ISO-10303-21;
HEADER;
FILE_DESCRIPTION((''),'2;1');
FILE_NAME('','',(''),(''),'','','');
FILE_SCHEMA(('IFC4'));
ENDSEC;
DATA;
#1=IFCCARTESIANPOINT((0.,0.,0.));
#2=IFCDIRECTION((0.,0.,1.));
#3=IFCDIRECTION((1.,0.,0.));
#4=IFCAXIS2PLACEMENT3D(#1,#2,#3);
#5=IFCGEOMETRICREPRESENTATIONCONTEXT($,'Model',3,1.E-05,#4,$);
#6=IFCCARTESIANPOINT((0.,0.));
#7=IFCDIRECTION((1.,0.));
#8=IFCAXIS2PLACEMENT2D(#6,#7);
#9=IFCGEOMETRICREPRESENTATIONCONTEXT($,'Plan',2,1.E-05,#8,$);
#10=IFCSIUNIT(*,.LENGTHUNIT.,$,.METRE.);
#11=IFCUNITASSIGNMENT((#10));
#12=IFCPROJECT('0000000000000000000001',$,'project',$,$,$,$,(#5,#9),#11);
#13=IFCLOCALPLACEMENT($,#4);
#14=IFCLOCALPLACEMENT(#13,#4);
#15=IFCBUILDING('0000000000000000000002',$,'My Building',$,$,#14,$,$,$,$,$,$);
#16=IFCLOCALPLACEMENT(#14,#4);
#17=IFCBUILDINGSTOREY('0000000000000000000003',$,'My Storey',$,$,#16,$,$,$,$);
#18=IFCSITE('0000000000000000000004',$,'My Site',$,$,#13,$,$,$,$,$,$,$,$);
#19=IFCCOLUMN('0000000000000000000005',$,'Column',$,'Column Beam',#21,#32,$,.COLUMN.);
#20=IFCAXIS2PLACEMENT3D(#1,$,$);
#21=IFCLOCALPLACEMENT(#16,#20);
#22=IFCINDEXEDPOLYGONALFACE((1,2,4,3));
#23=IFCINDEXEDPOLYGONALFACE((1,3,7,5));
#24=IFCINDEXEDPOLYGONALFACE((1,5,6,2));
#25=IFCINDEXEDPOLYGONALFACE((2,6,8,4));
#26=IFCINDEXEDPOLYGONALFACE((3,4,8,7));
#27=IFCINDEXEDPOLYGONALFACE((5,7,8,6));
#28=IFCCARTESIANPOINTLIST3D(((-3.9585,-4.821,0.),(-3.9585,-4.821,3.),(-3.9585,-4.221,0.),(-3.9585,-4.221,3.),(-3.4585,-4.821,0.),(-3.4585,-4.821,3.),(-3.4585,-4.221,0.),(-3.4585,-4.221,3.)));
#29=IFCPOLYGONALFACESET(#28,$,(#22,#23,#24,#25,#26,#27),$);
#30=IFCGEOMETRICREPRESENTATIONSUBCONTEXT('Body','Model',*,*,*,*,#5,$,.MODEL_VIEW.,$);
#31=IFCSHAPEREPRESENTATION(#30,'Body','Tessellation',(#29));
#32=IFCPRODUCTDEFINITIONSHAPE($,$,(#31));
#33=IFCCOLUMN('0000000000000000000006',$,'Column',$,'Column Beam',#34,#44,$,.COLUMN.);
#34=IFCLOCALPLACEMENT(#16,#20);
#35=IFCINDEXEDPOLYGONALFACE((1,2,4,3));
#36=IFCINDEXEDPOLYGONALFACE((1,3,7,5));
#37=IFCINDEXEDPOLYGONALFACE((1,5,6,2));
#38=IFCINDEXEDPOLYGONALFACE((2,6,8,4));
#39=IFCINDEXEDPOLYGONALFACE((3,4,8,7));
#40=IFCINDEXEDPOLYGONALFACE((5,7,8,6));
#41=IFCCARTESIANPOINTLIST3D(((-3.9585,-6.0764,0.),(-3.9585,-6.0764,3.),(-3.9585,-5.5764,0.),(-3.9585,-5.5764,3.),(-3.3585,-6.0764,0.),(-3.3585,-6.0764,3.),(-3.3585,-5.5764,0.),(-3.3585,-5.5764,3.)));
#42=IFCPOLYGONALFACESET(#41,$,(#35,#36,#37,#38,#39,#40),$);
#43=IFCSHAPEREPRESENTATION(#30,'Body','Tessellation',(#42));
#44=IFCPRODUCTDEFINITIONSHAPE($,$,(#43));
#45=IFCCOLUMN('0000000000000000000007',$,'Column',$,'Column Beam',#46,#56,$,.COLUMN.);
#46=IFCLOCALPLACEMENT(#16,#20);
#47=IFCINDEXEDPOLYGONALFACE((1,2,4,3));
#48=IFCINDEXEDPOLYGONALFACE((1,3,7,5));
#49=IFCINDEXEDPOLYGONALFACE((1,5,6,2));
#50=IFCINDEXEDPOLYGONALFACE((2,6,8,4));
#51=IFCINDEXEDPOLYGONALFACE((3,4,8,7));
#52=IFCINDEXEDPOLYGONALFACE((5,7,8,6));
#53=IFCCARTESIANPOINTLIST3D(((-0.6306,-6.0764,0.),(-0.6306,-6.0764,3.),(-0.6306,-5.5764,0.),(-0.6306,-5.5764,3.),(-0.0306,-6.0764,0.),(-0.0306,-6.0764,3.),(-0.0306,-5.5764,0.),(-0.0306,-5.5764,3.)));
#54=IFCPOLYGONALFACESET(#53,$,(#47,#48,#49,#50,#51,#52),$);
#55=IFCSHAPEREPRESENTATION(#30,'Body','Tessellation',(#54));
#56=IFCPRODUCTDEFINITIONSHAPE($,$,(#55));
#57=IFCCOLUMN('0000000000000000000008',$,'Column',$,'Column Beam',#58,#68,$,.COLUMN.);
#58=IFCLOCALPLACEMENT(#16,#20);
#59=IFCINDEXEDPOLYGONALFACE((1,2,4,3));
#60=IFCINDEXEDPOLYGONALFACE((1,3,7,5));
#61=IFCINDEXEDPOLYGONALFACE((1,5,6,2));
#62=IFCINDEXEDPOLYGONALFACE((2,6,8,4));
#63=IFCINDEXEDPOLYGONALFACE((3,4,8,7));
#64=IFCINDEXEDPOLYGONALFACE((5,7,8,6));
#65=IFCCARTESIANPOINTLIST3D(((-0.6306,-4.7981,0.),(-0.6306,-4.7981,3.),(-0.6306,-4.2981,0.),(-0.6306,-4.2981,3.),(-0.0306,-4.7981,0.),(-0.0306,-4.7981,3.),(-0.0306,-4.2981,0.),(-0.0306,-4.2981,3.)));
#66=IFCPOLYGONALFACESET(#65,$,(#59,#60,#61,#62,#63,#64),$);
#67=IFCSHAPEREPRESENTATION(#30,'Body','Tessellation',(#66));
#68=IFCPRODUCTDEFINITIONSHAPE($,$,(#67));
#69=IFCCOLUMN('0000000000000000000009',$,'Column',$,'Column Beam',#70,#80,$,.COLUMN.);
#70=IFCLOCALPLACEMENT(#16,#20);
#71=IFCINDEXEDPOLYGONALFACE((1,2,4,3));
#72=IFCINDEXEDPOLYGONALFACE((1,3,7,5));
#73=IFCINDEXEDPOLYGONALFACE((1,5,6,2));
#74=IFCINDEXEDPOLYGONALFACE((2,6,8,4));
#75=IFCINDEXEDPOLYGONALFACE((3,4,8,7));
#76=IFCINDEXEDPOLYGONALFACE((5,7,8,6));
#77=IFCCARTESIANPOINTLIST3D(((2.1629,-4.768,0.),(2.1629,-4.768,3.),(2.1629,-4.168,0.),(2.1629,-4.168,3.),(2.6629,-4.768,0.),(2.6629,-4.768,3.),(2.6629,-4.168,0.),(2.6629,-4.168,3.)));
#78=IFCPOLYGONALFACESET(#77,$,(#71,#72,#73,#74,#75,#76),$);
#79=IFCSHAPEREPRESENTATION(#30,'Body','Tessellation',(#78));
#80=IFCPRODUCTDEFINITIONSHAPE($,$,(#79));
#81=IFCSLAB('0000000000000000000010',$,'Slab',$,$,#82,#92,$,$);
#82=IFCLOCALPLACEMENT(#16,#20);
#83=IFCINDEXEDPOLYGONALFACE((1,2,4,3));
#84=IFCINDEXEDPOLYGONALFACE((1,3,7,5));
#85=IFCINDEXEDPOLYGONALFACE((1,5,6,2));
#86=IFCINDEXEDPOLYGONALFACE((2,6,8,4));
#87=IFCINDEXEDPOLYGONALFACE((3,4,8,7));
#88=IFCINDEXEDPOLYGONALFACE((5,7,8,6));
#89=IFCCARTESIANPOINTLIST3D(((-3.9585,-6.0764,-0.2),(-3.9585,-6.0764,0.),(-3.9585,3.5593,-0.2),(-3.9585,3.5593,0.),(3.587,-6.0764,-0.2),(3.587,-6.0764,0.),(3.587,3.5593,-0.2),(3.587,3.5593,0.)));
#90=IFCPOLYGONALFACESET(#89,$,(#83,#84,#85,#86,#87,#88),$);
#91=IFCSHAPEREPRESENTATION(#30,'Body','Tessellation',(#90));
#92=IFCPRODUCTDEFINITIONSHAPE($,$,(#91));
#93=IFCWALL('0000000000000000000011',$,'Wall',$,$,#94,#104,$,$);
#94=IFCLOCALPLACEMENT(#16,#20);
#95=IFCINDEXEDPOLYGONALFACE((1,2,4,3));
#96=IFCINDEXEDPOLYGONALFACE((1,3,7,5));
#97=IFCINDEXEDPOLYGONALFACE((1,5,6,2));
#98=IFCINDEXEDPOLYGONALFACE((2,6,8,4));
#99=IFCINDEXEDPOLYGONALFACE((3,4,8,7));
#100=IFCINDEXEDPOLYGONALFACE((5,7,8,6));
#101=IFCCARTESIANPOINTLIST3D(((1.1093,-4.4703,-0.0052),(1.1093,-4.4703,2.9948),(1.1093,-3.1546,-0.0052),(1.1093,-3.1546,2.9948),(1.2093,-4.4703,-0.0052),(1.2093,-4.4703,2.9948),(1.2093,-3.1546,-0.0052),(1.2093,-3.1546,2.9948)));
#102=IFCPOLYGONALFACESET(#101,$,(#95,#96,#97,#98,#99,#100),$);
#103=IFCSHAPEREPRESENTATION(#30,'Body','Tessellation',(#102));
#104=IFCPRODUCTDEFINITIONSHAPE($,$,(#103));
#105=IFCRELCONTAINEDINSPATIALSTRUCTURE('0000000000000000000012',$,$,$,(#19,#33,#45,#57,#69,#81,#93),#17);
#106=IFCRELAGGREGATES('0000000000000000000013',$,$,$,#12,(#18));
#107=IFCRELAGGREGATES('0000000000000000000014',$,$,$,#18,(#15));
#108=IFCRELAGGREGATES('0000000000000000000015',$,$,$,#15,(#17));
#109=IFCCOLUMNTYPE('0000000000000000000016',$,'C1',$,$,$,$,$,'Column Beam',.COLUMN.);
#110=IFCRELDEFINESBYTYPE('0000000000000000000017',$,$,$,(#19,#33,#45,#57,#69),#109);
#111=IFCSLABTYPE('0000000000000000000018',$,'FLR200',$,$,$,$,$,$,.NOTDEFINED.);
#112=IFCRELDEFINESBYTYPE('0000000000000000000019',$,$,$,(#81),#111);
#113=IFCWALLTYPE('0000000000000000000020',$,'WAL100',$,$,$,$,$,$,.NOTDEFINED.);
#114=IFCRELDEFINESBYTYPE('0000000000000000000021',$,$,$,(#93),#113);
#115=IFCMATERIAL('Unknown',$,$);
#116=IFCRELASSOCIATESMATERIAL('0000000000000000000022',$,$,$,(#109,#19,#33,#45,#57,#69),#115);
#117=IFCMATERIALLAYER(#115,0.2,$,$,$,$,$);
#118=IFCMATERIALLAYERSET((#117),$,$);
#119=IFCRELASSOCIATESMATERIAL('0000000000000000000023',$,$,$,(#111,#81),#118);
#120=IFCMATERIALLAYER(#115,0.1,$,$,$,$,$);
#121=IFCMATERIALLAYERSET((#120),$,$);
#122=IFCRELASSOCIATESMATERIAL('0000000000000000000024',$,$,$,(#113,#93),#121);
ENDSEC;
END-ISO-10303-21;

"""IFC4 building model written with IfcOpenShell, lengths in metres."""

from ifc_helpers import new_model, si_unit, frame, origin_with_axes, origin_2d_with_axis, place, context, subcontext, project, spatial, line, indexed_curve, outline, extrude, material, layer, layer_set, layer_usage, material_profile, profile_set, profile_usage, type_object, element, save


model = new_model("IFC4")

# Units and contexts
model_context = context("Model", 3, precision=1e-05, world=origin_with_axes())
plan_context = context("Plan", 2, precision=1e-05, world=origin_2d_with_axis())
body_context_1 = subcontext(model_context, "Body", "Model", "MODEL_VIEW")
ifc_project = project(units=[si_unit("LENGTHUNIT", "METRE")], contexts=[model_context, plan_context])

# Site, building, storey
site_placement = place(None, origin_with_axes())
site = spatial("IfcSite", under=ifc_project, at=site_placement, Name="My Site")
building_placement = place(site_placement, origin_with_axes())
building = spatial("IfcBuilding", under=site, at=building_placement, Name="My Building")
storey_placement = place(building_placement, origin_with_axes())
storey = spatial("IfcBuildingStorey", under=building, at=storey_placement, Name="My Storey")

# Columns
ifc_material = material(Name="Unknown")
ifc_material_profile = material_profile(ifc_material, outline(indexed_curve([(-0.25, -0.3), (0.25, -0.3), (0.25, 0.3), (-0.25, 0.3), (-0.25, -0.3)])))
ifc_profile_set = profile_set([ifc_material_profile])
ifc_profile_usage_1 = profile_usage(ifc_profile_set, cardinal=5)
column_type = type_object("IfcColumnType", Name="C1", ElementType="Column Beam", PredefinedType="COLUMN", material=ifc_profile_set)
column_1_placement = place(storey_placement, frame((-3.7085, -4.521, 0.0), z_axis=(0.0, 0.0, 1.0), x_axis=(1.0, 0.0, 0.0)))
element("IfcColumn", 1, at=column_1_placement, inside=storey, type_object=column_type, material=ifc_profile_usage_1, Name="Column", ObjectType="Column Beam", PredefinedType="COLUMN", context=body_context_1, shape_type="SweptSolid", body=[
    extrude(outline(indexed_curve([(-0.25, -0.3), (0.25, -0.3), (0.25, 0.3), (-0.25, 0.3), (-0.25, -0.3)])), origin_with_axes(), (0.0, 0.0, 1.0), 3.0),
])
ifc_profile_usage_2 = profile_usage(ifc_profile_set, cardinal=5)
column_2_placement = place(storey_placement, frame((-3.6585, -5.8264, 0.0), z_axis=(0.0, 0.0, 1.0), x_axis=(0.0, 1.0, 0.0)))
element("IfcColumn", 2, at=column_2_placement, inside=storey, type_object=column_type, material=ifc_profile_usage_2, Name="Column", ObjectType="Column Beam", PredefinedType="COLUMN", context=body_context_1, shape_type="SweptSolid", body=[
    extrude(outline(indexed_curve([(-0.25, -0.3), (0.25, -0.3), (0.25, 0.3), (-0.25, 0.3), (-0.25, -0.3)])), origin_with_axes(), (0.0, 0.0, 1.0), 3.0),
])
ifc_profile_usage_3 = profile_usage(ifc_profile_set, cardinal=5)
column_3_placement = place(storey_placement, frame((-0.3306, -5.8264, 0.0), z_axis=(0.0, 0.0, 1.0), x_axis=(0.0, 1.0, 0.0)))
element("IfcColumn", 3, at=column_3_placement, inside=storey, type_object=column_type, material=ifc_profile_usage_3, Name="Column", ObjectType="Column Beam", PredefinedType="COLUMN", context=body_context_1, shape_type="SweptSolid", body=[
    extrude(outline(indexed_curve([(-0.25, -0.3), (0.25, -0.3), (0.25, 0.3), (-0.25, 0.3), (-0.25, -0.3)])), origin_with_axes(), (0.0, 0.0, 1.0), 3.0),
])
ifc_profile_usage_4 = profile_usage(ifc_profile_set, cardinal=5)
column_4_placement = place(storey_placement, frame((-0.3306, -4.5481, 0.0), z_axis=(0.0, 0.0, 1.0), x_axis=(0.0, 1.0, 0.0)))
element("IfcColumn", 4, at=column_4_placement, inside=storey, type_object=column_type, material=ifc_profile_usage_4, Name="Column", ObjectType="Column Beam", PredefinedType="COLUMN", context=body_context_1, shape_type="SweptSolid", body=[
    extrude(outline(indexed_curve([(-0.25, -0.3), (0.25, -0.3), (0.25, 0.3), (-0.25, 0.3), (-0.25, -0.3)])), origin_with_axes(), (0.0, 0.0, 1.0), 3.0),
])
ifc_profile_usage_5 = profile_usage(ifc_profile_set, cardinal=5)
column_5_placement = place(storey_placement, frame((2.4129, -4.468, 0.0), z_axis=(0.0, 0.0, 1.0), x_axis=(1.0, 0.0, 0.0)))
element("IfcColumn", 5, at=column_5_placement, inside=storey, type_object=column_type, material=ifc_profile_usage_5, Name="Column", ObjectType="Column Beam", PredefinedType="COLUMN", context=body_context_1, shape_type="SweptSolid", body=[
    extrude(outline(indexed_curve([(-0.25, -0.3), (0.25, -0.3), (0.25, 0.3), (-0.25, 0.3), (-0.25, -0.3)])), origin_with_axes(), (0.0, 0.0, 1.0), 3.0),
])

# Slab
ifc_layer_1 = layer(ifc_material, 0.2)
ifc_layer_set_1 = layer_set([ifc_layer_1])
ifc_layer_usage_1 = layer_usage(ifc_layer_set_1, "AXIS3", "POSITIVE", -0.2)
slab_type = type_object("IfcSlabType", Name="FLR200", PredefinedType="NOTDEFINED", material=ifc_layer_set_1)
slab_placement = place(storey_placement, frame((-3.9585, -6.0764, 0.0), z_axis=(0.0, 0.0, 1.0), x_axis=(1.0, 0.0, 0.0)))
element("IfcSlab", 6, at=slab_placement, inside=storey, type_object=slab_type, material=ifc_layer_usage_1, Name="Slab", context=body_context_1, shape_type="SweptSolid", body=[
    extrude(outline(indexed_curve([(0.0, 0.0), (0.0, 9.6358), (7.5455, 9.6358), (7.5455, 0.0001), (0.0, 0.0)])), frame((0.0, 0.0, -0.2), z_axis=(0.0, 0.0, 1.0), x_axis=(1.0, 0.0, 0.0)), (0.0, 0.0, 1.0), 0.2),
])

# Wall
ifc_layer_2 = layer(ifc_material, 0.1)
ifc_layer_set_2 = layer_set([ifc_layer_2])
ifc_layer_usage_2 = layer_usage(ifc_layer_set_2, "AXIS2", "POSITIVE", 0.0)
wall_type_1 = type_object("IfcWallType", Name="WAL100", PredefinedType="NOTDEFINED", material=ifc_layer_set_2)
wall_1_placement = place(storey_placement, frame((1.2093, -4.4703, -0.0052), z_axis=(0.0, 0.0, 1.0), x_axis=(0.0, 1.0, 0.0)))
element("IfcWall", 7, at=wall_1_placement, inside=storey, type_object=wall_type_1, material=ifc_layer_usage_2, Name="Wall", context=body_context_1, shape_type="SweptSolid", body=[
    extrude(outline(indexed_curve([(0.0, 0.0), (0.0, 0.1), (1.3157, 0.1), (1.3157, 0.0)], segments=[line(1, 2, 3, 4, 1)])), origin_with_axes(), (0.0, 0.0, 1.0), 3.0),
])

save(model, "model.ifc")
